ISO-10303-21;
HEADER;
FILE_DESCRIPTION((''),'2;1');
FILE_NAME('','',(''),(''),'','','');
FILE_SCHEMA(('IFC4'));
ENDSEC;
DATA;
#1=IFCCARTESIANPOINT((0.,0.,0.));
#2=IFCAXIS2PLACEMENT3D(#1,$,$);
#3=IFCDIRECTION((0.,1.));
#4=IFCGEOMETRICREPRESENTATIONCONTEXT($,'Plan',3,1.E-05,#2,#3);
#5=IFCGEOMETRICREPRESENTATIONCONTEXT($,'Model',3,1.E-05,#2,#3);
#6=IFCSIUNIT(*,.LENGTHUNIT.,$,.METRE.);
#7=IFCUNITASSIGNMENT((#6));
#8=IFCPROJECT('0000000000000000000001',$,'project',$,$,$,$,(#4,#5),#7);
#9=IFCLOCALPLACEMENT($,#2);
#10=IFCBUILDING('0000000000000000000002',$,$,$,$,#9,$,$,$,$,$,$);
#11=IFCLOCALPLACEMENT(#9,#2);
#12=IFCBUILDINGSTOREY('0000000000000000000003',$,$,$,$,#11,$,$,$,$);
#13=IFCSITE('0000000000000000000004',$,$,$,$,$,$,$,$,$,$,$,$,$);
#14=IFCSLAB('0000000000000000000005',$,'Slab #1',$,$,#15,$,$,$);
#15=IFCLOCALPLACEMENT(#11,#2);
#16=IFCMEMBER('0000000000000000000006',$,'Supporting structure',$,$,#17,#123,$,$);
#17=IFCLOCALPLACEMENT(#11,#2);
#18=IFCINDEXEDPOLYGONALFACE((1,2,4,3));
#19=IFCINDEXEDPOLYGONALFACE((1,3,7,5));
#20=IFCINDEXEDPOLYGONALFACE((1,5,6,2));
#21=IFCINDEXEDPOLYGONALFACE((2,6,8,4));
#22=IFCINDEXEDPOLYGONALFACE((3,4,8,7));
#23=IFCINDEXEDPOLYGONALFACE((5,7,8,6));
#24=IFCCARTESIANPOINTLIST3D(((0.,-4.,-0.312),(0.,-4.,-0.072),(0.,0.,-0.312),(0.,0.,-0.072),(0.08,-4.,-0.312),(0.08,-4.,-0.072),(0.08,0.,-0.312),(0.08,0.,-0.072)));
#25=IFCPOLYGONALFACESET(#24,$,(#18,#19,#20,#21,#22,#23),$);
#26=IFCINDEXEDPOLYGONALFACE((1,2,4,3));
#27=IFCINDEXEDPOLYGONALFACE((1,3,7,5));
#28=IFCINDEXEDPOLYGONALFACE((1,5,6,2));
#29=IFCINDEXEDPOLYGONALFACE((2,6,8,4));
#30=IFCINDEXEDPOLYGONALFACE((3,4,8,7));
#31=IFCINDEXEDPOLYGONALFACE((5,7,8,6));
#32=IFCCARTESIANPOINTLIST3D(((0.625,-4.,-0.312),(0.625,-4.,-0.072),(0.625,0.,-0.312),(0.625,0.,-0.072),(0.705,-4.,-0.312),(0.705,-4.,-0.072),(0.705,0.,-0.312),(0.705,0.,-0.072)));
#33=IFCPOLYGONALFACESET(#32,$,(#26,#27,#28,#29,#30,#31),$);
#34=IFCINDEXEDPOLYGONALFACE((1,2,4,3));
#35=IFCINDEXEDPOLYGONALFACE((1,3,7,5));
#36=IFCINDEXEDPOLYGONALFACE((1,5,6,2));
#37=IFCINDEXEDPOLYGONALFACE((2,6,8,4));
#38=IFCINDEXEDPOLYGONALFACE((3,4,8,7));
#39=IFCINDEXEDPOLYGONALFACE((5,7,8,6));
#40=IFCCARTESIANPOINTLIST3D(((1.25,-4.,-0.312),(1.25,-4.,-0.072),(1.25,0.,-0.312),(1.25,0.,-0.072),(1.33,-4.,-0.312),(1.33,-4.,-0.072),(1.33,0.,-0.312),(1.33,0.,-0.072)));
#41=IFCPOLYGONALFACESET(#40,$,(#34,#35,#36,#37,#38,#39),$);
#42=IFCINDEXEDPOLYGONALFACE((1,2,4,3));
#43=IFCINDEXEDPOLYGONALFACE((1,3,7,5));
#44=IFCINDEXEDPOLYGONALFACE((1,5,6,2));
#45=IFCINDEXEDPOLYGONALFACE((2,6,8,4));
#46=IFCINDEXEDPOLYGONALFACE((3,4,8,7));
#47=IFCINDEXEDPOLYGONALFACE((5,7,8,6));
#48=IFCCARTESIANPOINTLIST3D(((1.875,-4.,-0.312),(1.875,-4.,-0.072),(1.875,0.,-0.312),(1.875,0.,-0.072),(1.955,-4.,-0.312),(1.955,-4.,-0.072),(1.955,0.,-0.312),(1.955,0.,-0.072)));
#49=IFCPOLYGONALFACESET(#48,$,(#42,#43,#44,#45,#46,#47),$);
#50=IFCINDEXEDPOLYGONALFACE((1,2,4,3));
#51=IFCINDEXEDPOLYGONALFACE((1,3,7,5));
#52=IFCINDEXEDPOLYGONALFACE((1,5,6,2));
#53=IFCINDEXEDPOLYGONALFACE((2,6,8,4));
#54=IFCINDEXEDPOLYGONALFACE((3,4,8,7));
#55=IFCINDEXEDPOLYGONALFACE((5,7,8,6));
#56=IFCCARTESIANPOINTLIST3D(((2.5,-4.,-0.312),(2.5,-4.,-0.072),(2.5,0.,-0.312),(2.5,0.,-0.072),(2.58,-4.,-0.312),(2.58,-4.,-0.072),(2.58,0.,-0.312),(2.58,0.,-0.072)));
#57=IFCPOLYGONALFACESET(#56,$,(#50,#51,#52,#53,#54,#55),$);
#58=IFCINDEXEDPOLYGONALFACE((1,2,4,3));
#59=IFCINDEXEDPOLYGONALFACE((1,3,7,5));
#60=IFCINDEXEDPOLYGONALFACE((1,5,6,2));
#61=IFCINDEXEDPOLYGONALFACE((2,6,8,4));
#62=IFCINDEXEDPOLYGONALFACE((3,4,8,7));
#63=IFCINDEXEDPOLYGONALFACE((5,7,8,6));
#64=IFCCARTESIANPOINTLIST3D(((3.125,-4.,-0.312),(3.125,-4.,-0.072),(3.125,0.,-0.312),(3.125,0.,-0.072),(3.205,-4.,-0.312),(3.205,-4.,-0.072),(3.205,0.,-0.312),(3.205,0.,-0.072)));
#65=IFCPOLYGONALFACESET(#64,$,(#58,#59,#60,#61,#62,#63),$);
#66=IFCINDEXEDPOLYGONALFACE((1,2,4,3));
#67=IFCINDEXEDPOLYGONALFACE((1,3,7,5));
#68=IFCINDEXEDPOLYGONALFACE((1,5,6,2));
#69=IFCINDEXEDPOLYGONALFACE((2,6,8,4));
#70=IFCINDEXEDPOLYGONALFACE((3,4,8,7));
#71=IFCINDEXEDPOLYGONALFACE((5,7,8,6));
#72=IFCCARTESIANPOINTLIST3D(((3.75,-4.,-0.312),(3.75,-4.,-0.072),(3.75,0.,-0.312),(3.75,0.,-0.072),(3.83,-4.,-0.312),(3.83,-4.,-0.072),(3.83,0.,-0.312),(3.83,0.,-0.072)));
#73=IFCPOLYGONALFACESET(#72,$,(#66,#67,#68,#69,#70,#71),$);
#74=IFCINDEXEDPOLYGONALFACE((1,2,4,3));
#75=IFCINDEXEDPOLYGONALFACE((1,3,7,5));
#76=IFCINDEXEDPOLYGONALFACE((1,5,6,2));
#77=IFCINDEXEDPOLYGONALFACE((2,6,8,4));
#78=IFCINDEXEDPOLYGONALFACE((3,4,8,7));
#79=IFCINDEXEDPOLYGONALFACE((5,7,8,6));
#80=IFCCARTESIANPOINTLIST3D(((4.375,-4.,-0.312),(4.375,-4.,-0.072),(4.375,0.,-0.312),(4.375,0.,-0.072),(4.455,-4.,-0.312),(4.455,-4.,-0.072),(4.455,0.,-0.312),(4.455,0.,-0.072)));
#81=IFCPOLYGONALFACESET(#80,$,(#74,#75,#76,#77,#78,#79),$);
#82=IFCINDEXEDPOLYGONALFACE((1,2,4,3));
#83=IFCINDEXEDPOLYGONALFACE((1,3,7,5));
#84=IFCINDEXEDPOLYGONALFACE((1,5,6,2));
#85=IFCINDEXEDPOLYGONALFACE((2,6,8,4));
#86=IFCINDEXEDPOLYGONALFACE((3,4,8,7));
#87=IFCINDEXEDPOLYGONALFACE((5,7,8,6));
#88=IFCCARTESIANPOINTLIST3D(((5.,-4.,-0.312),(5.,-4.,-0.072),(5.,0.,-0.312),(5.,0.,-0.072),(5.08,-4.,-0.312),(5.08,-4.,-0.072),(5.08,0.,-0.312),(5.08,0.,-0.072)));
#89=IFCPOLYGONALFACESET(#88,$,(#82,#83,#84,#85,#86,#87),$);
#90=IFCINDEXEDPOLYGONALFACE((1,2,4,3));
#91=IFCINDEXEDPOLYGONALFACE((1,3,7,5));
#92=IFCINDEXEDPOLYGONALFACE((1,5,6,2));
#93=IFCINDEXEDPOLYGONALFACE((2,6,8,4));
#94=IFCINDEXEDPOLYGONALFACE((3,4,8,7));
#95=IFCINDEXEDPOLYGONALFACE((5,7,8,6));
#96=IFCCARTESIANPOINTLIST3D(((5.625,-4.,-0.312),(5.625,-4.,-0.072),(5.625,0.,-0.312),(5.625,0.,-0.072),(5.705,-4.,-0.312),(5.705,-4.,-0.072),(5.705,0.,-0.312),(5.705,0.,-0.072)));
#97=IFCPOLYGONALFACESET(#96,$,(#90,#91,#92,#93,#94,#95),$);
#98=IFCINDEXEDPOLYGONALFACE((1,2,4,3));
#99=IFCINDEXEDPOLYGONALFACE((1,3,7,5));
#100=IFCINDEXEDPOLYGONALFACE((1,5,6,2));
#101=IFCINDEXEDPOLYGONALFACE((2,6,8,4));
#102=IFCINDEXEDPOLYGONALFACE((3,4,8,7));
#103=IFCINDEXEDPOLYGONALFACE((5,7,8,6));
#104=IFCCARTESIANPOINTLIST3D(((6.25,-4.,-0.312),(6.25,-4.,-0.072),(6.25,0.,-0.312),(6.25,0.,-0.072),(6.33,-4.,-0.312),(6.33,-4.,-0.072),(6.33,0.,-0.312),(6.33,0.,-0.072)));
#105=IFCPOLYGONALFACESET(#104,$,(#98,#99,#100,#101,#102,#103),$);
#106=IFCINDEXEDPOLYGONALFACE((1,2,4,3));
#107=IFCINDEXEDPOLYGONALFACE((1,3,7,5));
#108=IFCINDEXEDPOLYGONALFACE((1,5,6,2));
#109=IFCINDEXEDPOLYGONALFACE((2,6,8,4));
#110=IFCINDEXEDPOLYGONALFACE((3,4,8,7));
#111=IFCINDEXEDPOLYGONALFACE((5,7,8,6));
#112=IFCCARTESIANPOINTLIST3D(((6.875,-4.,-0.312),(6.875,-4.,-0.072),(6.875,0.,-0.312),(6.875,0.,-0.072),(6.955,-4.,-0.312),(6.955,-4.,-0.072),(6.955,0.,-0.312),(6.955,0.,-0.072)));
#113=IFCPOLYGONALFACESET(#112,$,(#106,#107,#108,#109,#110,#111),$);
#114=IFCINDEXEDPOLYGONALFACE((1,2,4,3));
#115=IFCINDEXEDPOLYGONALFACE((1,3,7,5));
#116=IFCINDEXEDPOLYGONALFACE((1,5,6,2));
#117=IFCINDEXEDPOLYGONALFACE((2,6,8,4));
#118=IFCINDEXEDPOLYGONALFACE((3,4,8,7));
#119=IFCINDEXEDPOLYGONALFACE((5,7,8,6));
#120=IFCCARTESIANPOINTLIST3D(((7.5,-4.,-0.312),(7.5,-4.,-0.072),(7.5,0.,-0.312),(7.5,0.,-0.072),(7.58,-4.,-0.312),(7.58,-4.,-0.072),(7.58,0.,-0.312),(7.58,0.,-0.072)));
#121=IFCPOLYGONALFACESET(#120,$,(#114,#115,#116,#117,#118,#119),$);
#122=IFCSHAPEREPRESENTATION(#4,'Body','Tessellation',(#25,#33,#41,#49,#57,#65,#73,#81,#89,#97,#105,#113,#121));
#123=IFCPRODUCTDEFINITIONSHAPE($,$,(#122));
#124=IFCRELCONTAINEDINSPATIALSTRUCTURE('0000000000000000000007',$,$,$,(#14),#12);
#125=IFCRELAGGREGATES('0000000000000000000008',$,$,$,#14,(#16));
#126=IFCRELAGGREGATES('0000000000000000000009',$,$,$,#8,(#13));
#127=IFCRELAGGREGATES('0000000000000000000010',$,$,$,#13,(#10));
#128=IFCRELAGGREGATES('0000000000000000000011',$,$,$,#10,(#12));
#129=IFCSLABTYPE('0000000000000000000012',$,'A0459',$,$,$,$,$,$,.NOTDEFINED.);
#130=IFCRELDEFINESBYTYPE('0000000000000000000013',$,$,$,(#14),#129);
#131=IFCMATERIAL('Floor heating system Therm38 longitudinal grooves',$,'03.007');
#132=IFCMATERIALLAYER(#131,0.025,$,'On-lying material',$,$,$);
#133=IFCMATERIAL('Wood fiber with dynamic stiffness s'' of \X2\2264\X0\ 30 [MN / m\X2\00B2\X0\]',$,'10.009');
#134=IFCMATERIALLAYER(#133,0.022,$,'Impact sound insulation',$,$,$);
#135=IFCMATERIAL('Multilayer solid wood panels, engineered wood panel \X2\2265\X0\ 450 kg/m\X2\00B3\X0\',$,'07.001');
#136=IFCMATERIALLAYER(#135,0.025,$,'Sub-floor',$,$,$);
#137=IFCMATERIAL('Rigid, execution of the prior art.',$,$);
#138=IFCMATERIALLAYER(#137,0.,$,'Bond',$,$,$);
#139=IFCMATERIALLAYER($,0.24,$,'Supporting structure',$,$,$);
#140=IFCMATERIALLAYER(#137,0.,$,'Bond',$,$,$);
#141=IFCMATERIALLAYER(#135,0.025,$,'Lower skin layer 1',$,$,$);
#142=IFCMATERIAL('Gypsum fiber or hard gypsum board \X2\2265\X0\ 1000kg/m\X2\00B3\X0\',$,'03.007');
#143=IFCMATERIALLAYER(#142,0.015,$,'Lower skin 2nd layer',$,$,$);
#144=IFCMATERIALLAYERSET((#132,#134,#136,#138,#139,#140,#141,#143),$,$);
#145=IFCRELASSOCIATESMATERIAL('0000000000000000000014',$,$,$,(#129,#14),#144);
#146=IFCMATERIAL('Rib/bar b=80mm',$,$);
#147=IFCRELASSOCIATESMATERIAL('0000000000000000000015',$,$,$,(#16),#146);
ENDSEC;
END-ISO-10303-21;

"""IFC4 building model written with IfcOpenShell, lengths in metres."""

from ifc_helpers import new_model, si_unit, direction, frame, frame_2d, origin, place, context, project, spatial, rectangle, extrude, material, layer, layer_set, type_object, element, aggregate, save


model = new_model("IFC4")

# Units and contexts
plan_context = context("Plan", 3, precision=1e-05, world=origin(), true_north=direction((0.0, 1.0)))
model_context = context("Model", 3, precision=1e-05, world=origin(), true_north=direction((0.0, 1.0)))
ifc_project = project(units=[si_unit("LENGTHUNIT", "METRE")], contexts=[plan_context, model_context])

# Site, building, storey
site = spatial("IfcSite", under=ifc_project)
building_placement = place(None, origin())
building = spatial("IfcBuilding", under=site, at=building_placement)
storey_placement = place(building_placement, origin())
storey = spatial("IfcBuildingStorey", under=building, at=storey_placement)

# Slab, member
ifc_material_1 = material(Name="Floor heating system Therm38 longitudinal grooves", Category="03.007")
ifc_layer_1 = layer(ifc_material_1, 0.025, Name="On-lying material")
ifc_material_2 = material(Name="Wood fiber with dynamic stiffness s' of ≤ 30 [MN / m²]", Category="10.009")
ifc_layer_2 = layer(ifc_material_2, 0.022, Name="Impact sound insulation")
ifc_material_3 = material(Name="Multilayer solid wood panels, engineered wood panel ≥ 450 kg/m³", Category="07.001")
ifc_layer_3 = layer(ifc_material_3, 0.025, Name="Sub-floor")
ifc_material_4 = material(Name="Rigid, execution of the prior art.")
ifc_layer_4 = layer(ifc_material_4, 0.0, Name="Bond")
ifc_layer_5 = layer(None, 0.24, Name="Supporting structure")
ifc_layer_6 = layer(ifc_material_4, 0.0, Name="Bond")
ifc_layer_7 = layer(ifc_material_3, 0.025, Name="Lower skin layer 1")
ifc_material_5 = material(Name="Gypsum fiber or hard gypsum board ≥ 1000kg/m³", Category="03.007")
ifc_layer_8 = layer(ifc_material_5, 0.015, Name="Lower skin 2nd layer")
ifc_layer_set = layer_set([ifc_layer_1, ifc_layer_2, ifc_layer_3, ifc_layer_4, ifc_layer_5, ifc_layer_6, ifc_layer_7, ifc_layer_8])
slab_type = type_object("IfcSlabType", Name="A0459", PredefinedType="NOTDEFINED", material=ifc_layer_set)
slab_placement = place(None, frame((0.0, 0.0, 0.0), z_axis=(0.0, 0.0, -1.0), x_axis=(1.0, 0.0, 0.0)))
slab = element("IfcSlab", 1, at=slab_placement, inside=storey, type_object=slab_type, material=ifc_layer_set, Name="Slab #1")
ifc_material_6 = material(Name="Rib/bar b=80mm")
member_1_placement = place(slab_placement, origin())
member_1 = element("IfcMember", 2, at=member_1_placement, material=ifc_material_6, Name="Supporting structure", context=plan_context, shape_type="SweptSolid", body=[
    extrude(rectangle(XDim=0.08, YDim=0.24, at=frame_2d((0.04, 0.12), x_axis=(1.0, 0.0))), frame((0.0, 4.0, 0.072), z_axis=(0.0, -1.0, 0.0), x_axis=(1.0, 0.0, 0.0)), (0.0, 0.0, 1.0), 4.0),
    extrude(rectangle(XDim=0.08, YDim=0.24, at=frame_2d((0.04, 0.12), x_axis=(1.0, 0.0))), frame((0.625, 4.0, 0.072), z_axis=(0.0, -1.0, 0.0), x_axis=(1.0, 0.0, 0.0)), (0.0, 0.0, 1.0), 4.0),
    extrude(rectangle(XDim=0.08, YDim=0.24, at=frame_2d((0.04, 0.12), x_axis=(1.0, 0.0))), frame((1.25, 4.0, 0.072), z_axis=(0.0, -1.0, 0.0), x_axis=(1.0, 0.0, 0.0)), (0.0, 0.0, 1.0), 4.0),
    extrude(rectangle(XDim=0.08, YDim=0.24, at=frame_2d((0.04, 0.12), x_axis=(1.0, 0.0))), frame((1.875, 4.0, 0.072), z_axis=(0.0, -1.0, 0.0), x_axis=(1.0, 0.0, 0.0)), (0.0, 0.0, 1.0), 4.0),
    extrude(rectangle(XDim=0.08, YDim=0.24, at=frame_2d((0.04, 0.12), x_axis=(1.0, 0.0))), frame((2.5, 4.0, 0.072), z_axis=(0.0, -1.0, 0.0), x_axis=(1.0, 0.0, 0.0)), (0.0, 0.0, 1.0), 4.0),
    extrude(rectangle(XDim=0.08, YDim=0.24, at=frame_2d((0.04, 0.12), x_axis=(1.0, 0.0))), frame((3.125, 4.0, 0.072), z_axis=(0.0, -1.0, 0.0), x_axis=(1.0, 0.0, 0.0)), (0.0, 0.0, 1.0), 4.0),
    extrude(rectangle(XDim=0.08, YDim=0.24, at=frame_2d((0.04, 0.12), x_axis=(1.0, 0.0))), frame((3.75, 4.0, 0.072), z_axis=(0.0, -1.0, 0.0), x_axis=(1.0, 0.0, 0.0)), (0.0, 0.0, 1.0), 4.0),
    extrude(rectangle(XDim=0.08, YDim=0.24, at=frame_2d((0.04, 0.12), x_axis=(1.0, 0.0))), frame((4.375, 4.0, 0.072), z_axis=(0.0, -1.0, 0.0), x_axis=(1.0, 0.0, 0.0)), (0.0, 0.0, 1.0), 4.0),
    extrude(rectangle(XDim=0.08, YDim=0.24, at=frame_2d((0.04, 0.12), x_axis=(1.0, 0.0))), frame((5.0, 4.0, 0.072), z_axis=(0.0, -1.0, 0.0), x_axis=(1.0, 0.0, 0.0)), (0.0, 0.0, 1.0), 4.0),
    extrude(rectangle(XDim=0.08, YDim=0.24, at=frame_2d((0.04, 0.12), x_axis=(1.0, 0.0))), frame((5.625, 4.0, 0.072), z_axis=(0.0, -1.0, 0.0), x_axis=(1.0, 0.0, 0.0)), (0.0, 0.0, 1.0), 4.0),
    extrude(rectangle(XDim=0.08, YDim=0.24, at=frame_2d((0.04, 0.12), x_axis=(1.0, 0.0))), frame((6.25, 4.0, 0.072), z_axis=(0.0, -1.0, 0.0), x_axis=(1.0, 0.0, 0.0)), (0.0, 0.0, 1.0), 4.0),
    extrude(rectangle(XDim=0.08, YDim=0.24, at=frame_2d((0.04, 0.12), x_axis=(1.0, 0.0))), frame((6.875, 4.0, 0.072), z_axis=(0.0, -1.0, 0.0), x_axis=(1.0, 0.0, 0.0)), (0.0, 0.0, 1.0), 4.0),
    extrude(rectangle(XDim=0.08, YDim=0.24, at=frame_2d((0.04, 0.12), x_axis=(1.0, 0.0))), frame((7.5, 4.0, 0.072), z_axis=(0.0, -1.0, 0.0), x_axis=(1.0, 0.0, 0.0)), (0.0, 0.0, 1.0), 4.0),
])
aggregate(slab, [member_1])

save(model, "model.ifc")
